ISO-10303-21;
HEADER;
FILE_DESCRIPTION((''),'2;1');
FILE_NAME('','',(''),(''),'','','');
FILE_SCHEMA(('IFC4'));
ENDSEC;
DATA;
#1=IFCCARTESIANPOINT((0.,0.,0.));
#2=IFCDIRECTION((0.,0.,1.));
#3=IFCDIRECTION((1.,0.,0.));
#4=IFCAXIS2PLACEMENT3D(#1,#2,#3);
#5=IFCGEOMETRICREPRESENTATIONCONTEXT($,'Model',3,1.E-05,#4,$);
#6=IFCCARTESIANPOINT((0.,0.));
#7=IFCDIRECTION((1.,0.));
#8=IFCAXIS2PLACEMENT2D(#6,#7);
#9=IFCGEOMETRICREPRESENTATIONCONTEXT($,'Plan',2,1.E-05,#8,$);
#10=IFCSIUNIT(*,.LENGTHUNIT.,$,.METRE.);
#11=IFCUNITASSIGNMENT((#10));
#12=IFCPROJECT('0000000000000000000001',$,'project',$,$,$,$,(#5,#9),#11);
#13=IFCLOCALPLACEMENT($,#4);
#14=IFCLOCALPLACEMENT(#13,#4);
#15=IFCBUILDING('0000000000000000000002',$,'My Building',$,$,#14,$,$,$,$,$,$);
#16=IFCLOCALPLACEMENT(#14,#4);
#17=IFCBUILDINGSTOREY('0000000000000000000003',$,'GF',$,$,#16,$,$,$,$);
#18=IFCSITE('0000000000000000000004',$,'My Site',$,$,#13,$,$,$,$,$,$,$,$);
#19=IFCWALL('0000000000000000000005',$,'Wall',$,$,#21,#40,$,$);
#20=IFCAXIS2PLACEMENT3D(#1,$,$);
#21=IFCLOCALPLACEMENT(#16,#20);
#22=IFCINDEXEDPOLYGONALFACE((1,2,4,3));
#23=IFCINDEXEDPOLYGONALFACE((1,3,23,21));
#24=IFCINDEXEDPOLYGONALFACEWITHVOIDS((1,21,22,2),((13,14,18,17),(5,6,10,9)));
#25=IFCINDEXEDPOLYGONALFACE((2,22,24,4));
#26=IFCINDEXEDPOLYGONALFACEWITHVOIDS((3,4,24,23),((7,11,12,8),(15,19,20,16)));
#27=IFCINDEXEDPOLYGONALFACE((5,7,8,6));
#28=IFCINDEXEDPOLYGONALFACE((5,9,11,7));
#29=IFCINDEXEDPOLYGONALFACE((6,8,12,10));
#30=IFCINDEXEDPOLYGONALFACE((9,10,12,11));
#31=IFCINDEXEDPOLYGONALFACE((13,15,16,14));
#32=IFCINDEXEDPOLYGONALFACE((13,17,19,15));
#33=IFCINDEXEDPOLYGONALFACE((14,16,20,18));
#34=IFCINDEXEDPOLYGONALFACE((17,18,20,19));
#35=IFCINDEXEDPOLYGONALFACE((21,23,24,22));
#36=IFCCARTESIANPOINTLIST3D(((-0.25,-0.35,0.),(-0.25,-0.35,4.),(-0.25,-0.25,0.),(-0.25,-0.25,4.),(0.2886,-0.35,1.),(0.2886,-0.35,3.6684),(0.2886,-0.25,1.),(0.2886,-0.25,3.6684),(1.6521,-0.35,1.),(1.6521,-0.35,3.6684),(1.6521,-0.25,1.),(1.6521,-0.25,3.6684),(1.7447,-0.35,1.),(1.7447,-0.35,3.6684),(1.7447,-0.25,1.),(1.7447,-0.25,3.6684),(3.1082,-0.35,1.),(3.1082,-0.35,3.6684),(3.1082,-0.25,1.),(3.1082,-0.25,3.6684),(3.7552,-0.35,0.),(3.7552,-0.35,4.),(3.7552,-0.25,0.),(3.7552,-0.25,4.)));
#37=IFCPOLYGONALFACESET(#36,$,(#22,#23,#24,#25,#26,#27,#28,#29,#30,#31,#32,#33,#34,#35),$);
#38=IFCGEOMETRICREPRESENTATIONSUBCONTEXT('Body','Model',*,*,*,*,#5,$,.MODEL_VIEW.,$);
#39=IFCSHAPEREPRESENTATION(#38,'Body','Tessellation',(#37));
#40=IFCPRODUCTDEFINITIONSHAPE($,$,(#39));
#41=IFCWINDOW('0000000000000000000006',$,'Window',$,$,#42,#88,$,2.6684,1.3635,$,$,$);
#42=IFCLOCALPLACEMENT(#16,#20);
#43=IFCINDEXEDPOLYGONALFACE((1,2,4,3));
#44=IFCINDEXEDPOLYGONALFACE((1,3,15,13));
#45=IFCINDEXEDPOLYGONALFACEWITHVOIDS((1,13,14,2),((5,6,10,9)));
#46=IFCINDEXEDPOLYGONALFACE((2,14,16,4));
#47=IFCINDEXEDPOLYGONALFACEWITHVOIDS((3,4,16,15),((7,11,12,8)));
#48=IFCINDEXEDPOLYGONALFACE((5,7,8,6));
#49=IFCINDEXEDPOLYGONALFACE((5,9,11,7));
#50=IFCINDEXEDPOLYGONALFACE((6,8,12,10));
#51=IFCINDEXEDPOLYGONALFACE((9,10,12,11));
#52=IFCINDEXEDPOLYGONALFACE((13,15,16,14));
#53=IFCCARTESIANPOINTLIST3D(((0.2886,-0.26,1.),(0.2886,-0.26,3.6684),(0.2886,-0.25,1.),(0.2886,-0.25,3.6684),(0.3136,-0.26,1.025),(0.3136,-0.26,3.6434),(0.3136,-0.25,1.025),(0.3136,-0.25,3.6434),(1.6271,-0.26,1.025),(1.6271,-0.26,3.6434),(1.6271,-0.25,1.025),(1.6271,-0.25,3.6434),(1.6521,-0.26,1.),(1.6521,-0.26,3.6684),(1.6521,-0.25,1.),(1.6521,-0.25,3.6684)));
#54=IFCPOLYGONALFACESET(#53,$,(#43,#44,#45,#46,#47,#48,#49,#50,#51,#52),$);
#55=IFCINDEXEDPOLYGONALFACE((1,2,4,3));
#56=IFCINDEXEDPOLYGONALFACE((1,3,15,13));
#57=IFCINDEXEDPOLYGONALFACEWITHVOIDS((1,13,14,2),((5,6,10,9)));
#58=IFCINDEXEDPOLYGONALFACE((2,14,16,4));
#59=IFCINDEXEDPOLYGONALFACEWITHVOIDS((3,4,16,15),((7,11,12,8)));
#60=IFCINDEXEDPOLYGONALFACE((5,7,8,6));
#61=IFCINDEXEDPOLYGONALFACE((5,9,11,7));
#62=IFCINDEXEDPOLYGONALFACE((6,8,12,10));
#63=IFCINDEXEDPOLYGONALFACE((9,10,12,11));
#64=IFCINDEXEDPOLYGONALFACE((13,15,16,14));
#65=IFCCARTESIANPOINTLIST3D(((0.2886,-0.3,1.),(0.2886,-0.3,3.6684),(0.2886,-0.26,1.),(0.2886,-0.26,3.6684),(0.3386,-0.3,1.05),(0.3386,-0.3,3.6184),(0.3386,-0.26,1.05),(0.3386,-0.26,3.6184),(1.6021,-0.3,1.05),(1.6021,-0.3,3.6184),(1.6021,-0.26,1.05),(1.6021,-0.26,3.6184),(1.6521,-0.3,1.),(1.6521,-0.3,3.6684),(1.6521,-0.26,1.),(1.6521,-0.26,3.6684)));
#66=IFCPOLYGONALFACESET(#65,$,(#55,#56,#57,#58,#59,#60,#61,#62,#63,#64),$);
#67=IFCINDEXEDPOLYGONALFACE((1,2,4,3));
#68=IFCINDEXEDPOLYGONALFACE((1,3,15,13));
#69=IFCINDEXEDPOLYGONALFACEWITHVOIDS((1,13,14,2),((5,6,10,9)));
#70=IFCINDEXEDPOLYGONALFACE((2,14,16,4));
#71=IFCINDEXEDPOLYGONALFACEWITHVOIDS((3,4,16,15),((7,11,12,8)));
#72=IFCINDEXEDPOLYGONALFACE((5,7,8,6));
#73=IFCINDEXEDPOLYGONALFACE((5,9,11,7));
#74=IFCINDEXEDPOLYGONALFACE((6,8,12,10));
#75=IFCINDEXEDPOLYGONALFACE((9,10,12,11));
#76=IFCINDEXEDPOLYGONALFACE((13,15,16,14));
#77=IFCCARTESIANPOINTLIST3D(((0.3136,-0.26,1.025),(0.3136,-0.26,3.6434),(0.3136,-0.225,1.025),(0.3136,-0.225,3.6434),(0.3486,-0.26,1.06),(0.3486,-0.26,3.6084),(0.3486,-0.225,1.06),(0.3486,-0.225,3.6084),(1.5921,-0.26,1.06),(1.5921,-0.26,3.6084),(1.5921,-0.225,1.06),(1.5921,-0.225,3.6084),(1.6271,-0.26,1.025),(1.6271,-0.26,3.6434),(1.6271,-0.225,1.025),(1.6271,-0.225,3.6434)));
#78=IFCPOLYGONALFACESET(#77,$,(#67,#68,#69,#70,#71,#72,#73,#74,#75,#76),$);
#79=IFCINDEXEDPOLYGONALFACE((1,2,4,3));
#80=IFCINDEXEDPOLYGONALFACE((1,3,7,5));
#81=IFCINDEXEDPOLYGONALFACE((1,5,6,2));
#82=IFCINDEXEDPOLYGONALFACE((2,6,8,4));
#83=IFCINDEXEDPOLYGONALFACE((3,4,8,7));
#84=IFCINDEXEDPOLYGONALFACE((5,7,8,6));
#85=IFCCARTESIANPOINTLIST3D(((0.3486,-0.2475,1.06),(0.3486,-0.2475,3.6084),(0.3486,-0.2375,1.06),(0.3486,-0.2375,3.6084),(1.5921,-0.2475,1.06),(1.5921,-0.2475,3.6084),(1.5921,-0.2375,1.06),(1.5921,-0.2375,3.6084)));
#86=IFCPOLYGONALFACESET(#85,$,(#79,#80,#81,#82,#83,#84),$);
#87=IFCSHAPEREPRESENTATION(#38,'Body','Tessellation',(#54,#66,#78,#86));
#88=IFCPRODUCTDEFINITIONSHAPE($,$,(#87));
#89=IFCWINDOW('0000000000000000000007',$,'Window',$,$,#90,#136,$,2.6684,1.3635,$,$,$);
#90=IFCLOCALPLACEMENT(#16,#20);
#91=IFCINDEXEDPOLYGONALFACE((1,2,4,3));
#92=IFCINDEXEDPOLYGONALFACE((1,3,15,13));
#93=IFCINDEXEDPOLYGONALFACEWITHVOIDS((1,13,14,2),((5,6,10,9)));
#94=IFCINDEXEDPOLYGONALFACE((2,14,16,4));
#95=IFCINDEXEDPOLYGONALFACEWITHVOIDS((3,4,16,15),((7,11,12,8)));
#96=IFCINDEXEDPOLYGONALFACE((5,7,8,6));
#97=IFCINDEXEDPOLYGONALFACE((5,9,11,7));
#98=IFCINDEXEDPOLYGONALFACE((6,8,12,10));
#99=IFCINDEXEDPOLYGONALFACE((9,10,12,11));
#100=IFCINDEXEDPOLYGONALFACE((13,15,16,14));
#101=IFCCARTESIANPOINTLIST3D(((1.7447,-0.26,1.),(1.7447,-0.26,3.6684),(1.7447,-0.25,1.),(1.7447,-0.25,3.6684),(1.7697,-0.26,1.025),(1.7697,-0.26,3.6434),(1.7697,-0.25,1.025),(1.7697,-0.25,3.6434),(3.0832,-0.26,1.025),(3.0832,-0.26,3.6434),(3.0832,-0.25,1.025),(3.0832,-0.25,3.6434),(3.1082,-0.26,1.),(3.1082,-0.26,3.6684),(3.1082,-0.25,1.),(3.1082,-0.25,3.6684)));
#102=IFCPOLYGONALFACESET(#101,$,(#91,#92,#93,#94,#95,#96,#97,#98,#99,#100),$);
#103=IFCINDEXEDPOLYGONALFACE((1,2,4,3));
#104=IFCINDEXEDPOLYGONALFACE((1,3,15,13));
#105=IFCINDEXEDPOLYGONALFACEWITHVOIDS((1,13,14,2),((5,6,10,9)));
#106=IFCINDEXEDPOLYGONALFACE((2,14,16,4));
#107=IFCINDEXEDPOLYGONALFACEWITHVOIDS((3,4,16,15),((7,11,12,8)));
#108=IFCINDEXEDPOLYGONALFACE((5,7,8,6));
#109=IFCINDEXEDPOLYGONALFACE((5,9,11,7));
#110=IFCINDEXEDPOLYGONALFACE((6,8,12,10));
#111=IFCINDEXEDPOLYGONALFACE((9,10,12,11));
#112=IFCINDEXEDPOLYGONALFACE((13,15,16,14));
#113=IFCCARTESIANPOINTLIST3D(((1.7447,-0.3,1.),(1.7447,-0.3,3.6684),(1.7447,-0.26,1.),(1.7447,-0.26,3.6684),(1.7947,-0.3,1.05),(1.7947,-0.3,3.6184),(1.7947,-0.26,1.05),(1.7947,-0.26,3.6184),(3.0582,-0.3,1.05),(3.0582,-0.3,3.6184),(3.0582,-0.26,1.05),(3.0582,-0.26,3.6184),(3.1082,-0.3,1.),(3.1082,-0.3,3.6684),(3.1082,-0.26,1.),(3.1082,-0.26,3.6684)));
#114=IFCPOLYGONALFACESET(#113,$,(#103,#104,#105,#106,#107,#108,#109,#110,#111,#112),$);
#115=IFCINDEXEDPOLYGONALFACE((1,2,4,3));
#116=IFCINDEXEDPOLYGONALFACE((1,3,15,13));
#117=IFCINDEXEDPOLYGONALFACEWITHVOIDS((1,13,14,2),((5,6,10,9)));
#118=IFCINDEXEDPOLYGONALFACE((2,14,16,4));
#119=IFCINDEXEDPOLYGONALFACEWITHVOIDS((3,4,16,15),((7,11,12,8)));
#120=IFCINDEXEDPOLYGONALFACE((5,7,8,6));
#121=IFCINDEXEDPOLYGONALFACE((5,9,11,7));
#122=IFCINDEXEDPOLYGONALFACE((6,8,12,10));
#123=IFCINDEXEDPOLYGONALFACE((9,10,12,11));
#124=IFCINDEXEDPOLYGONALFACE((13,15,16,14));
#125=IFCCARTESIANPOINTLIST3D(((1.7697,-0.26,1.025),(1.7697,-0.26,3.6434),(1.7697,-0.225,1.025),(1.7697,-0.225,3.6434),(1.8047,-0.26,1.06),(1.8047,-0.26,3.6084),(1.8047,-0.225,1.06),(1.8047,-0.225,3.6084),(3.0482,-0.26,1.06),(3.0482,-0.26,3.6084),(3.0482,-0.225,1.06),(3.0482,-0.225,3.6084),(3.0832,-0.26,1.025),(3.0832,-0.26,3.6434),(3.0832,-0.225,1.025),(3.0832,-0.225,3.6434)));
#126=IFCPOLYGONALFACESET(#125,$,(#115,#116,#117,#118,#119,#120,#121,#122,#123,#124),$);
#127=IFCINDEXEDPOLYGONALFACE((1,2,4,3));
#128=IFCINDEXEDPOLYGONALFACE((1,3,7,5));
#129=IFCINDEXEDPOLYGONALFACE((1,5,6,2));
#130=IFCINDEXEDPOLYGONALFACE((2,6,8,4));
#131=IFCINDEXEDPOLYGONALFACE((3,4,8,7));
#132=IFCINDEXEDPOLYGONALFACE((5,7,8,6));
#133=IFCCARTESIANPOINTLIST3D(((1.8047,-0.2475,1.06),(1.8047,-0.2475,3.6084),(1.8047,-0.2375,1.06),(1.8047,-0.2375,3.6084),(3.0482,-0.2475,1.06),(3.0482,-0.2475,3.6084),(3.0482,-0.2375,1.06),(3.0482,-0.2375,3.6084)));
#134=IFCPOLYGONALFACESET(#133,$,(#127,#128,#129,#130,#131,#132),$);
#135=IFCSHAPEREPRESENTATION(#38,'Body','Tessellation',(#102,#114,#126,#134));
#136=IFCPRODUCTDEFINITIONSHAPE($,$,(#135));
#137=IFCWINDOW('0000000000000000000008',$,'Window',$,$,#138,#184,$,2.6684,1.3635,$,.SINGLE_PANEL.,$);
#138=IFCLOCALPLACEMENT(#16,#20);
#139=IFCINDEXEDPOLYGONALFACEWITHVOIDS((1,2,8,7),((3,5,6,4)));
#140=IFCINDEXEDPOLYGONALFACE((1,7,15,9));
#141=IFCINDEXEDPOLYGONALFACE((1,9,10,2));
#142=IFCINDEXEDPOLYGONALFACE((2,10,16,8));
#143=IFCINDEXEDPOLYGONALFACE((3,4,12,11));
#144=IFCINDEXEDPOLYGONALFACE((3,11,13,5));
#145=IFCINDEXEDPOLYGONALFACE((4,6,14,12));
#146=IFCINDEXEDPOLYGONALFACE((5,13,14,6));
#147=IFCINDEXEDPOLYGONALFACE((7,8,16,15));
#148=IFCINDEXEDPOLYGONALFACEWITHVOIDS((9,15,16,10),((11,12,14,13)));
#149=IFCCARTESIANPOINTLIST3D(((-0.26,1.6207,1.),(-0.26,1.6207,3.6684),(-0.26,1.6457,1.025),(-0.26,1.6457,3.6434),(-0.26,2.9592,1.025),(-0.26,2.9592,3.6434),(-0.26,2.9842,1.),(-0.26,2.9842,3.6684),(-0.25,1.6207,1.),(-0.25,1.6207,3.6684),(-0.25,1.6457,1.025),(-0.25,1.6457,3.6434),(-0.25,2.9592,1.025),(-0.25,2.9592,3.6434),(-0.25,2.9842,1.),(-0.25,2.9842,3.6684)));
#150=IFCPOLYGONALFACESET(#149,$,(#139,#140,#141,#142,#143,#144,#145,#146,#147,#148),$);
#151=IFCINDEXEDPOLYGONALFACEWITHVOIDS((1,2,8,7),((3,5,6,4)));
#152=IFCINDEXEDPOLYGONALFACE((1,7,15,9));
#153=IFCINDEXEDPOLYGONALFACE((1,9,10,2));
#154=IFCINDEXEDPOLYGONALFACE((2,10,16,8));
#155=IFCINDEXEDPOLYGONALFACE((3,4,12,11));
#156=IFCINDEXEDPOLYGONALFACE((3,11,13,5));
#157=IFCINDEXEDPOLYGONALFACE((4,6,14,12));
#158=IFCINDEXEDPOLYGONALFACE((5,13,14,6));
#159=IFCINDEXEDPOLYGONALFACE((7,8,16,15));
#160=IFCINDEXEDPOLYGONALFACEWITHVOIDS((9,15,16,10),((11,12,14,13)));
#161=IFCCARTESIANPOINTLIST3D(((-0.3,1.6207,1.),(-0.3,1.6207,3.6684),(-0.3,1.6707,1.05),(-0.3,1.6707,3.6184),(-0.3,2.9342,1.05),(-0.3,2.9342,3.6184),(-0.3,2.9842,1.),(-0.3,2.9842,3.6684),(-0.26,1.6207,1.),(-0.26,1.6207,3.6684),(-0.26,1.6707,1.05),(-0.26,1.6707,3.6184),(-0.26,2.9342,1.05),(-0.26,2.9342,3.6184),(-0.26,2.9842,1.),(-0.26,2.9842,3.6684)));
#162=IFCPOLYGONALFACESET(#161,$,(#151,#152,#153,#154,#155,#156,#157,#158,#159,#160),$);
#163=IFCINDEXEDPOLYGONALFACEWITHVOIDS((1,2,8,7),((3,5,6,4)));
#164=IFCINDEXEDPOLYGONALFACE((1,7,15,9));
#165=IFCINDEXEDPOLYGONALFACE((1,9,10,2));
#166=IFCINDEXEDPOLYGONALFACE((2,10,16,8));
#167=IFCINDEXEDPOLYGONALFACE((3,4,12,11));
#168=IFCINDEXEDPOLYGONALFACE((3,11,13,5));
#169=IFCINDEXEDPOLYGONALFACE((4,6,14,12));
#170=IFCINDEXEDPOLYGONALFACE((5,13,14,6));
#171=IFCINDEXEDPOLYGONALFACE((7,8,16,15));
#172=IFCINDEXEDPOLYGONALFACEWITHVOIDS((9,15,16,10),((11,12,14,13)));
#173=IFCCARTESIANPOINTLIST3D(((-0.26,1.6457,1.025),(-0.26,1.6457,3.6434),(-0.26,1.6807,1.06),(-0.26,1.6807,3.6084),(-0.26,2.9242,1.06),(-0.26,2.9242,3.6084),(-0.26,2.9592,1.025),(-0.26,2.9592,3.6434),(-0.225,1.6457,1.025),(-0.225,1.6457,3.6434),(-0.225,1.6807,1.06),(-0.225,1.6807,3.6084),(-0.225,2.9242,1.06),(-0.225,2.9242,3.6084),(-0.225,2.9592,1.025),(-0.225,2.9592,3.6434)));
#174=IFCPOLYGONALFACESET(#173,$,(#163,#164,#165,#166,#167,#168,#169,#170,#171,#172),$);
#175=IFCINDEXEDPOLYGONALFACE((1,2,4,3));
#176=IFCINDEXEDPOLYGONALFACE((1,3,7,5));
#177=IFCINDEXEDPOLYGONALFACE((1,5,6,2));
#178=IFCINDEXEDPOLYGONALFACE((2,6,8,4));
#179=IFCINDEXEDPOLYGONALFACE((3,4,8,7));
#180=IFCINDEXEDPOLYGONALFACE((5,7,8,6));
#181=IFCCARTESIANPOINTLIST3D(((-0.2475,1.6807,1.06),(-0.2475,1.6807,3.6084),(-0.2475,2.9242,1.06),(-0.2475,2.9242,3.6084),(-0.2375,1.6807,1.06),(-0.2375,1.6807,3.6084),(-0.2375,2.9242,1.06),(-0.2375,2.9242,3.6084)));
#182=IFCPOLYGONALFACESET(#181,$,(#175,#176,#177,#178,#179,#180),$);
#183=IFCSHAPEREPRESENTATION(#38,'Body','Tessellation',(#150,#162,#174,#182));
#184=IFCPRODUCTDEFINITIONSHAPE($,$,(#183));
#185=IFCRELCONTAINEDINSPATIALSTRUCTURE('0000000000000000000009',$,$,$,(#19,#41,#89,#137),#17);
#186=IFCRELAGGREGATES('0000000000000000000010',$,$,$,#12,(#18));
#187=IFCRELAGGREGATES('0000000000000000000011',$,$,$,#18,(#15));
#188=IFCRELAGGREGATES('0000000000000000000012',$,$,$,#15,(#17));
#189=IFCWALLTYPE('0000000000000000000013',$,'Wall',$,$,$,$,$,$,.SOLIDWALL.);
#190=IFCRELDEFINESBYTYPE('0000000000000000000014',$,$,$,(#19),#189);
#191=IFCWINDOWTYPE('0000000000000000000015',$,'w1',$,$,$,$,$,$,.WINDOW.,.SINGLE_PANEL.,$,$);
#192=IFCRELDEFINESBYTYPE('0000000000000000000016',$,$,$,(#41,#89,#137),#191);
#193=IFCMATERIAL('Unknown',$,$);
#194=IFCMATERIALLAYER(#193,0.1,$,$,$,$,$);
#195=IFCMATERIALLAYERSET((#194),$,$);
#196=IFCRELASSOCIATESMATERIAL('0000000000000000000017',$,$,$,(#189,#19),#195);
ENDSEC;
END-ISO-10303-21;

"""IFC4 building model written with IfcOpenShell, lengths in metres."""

from ifc_helpers import new_model, entity, si_unit, frame, origin_with_axes, origin_2d_with_axis, place, context, subcontext, project, spatial, line, indexed_curve, outline, extrude, shape, source, transform, mapped, material, layer, layer_set, layer_usage, type_object, type_shapes, element, fill, save


model = new_model("IFC4")

# Units and contexts
model_context = context("Model", 3, precision=1e-05, world=origin_with_axes())
plan_context = context("Plan", 2, precision=1e-05, world=origin_2d_with_axis())
body_context_1 = subcontext(model_context, "Body", "Model", "MODEL_VIEW")
body_context_2 = subcontext(plan_context, "Body", "Plan", "PLAN_VIEW")
ifc_project = project(units=[si_unit("LENGTHUNIT", "METRE")], contexts=[model_context, plan_context])

# Site, building, storey
site_placement = place(None, origin_with_axes())
site = spatial("IfcSite", under=ifc_project, at=site_placement, Name="My Site")
building_placement = place(site_placement, origin_with_axes())
building = spatial("IfcBuilding", under=site, at=building_placement, Name="My Building")
storey_placement = place(building_placement, origin_with_axes())
storey = spatial("IfcBuildingStorey", under=building, at=storey_placement, Name="GF")

# Shared definitions
ifc_material = material(Name="Unknown")

# Wall, openings, windows
ifc_layer_1 = layer(ifc_material, 0.1)
ifc_layer_set_1 = layer_set([ifc_layer_1])
wall_type = type_object("IfcWallType", Name="Wall", PredefinedType="SOLIDWALL", material=ifc_layer_set_1)
shared_shape_1 = source(origin_with_axes(), body_context_1, "Body", "SweptSolid", [
    extrude(outline(indexed_curve([(0.0, 0.0), (1.3635, 0.0), (1.3635, 2.6684), (0.0, 2.6684)], segments=[line(1, 2, 3, 4, 1)])), frame((0.0, -0.6, 0.0), z_axis=(0.0, -1.0, 0.0), x_axis=(1.0, 0.0, 0.0)), (0.0, 0.0, -1.0), 1.2),
])
window_type_1 = type_object("IfcWindowType", Name="w1", PartitioningType="SINGLE_PANEL", PredefinedType="WINDOW")
shared_shape_2 = source(origin_with_axes(), body_context_1, "Body", "SweptSolid", [
    extrude(outline(indexed_curve([(0.0, 0.0), (1.3635, 0.0), (1.3635, 2.6684), (0.0, 2.6684)], segments=[line(1, 2, 3, 4, 1)]), holes=[indexed_curve([(0.025, 0.025), (1.3385, 0.025), (1.3385, 2.6434), (0.025, 2.6434)], segments=[line(1, 2, 3, 4, 1)])]), frame((0.0, 0.09, 0.0), z_axis=(0.0, -1.0, 0.0), x_axis=(1.0, 0.0, 0.0)), (0.0, 0.0, -1.0), 0.01),
    extrude(outline(indexed_curve([(0.0, 0.0), (1.3635, 0.0), (1.3635, 2.6684), (0.0, 2.6684)], segments=[line(1, 2, 3, 4, 1)]), holes=[indexed_curve([(0.05, 0.05), (1.3135, 0.05), (1.3135, 2.6184), (0.05, 2.6184)], segments=[line(1, 2, 3, 4, 1)])]), frame((0.0, 0.05, 0.0), z_axis=(0.0, -1.0, 0.0), x_axis=(1.0, 0.0, 0.0)), (0.0, 0.0, -1.0), 0.04),
    extrude(outline(indexed_curve([(0.0, 0.0), (1.3135, 0.0), (1.3135, 2.6184), (0.0, 2.6184)], segments=[line(1, 2, 3, 4, 1)]), holes=[indexed_curve([(0.035, 0.035), (1.2785, 0.035), (1.2785, 2.5834), (0.035, 2.5834)], segments=[line(1, 2, 3, 4, 1)])]), frame((0.025, 0.09, 0.025), z_axis=(0.0, -1.0, 0.0), x_axis=(1.0, 0.0, 0.0)), (0.0, 0.0, -1.0), 0.035),
    extrude(outline(indexed_curve([(0.035, 0.035), (1.2785, 0.035), (1.2785, 2.5834), (0.035, 2.5834)], segments=[line(1, 2, 3, 4, 1)])), frame((0.025, 0.1025, 0.025), z_axis=(0.0, -1.0, 0.0), x_axis=(1.0, 0.0, 0.0)), (0.0, 0.0, -1.0), 0.01),
])
shared_shape_3 = source(origin_with_axes(), body_context_2, "Body", "Curve2D", [
    entity("IfcIndexedPolyCurve", entity("IfcCartesianPointList2D", [[0.05, 0.05], [1.3135, 0.05]])),
    entity("IfcIndexedPolyCurve", entity("IfcCartesianPointList2D", [[0.0, 0.1], [0.025, 0.1], [0.025, 0.09], [0.05, 0.09], [0.05, 0.05], [0.0, 0.05]]), [entity("IfcLineIndex", [1, 2, 3, 4, 5, 6, 1])]),
    entity("IfcIndexedPolyCurve", entity("IfcCartesianPointList2D", [[1.3635, 0.1], [1.3385, 0.1], [1.3385, 0.09], [1.3135, 0.09], [1.3135, 0.05], [1.3635, 0.05]]), [entity("IfcLineIndex", [1, 2, 3, 4, 5, 6, 1])]),
    entity("IfcIndexedPolyCurve", entity("IfcCartesianPointList2D", [[0.025, 0.09], [0.06, 0.09], [0.06, 0.125], [0.025, 0.125]]), [entity("IfcLineIndex", [1, 2, 3, 4, 1])]),
    entity("IfcIndexedPolyCurve", entity("IfcCartesianPointList2D", [[1.3385, 0.09], [1.3035, 0.09], [1.3035, 0.125], [1.3385, 0.125]]), [entity("IfcLineIndex", [1, 2, 3, 4, 1])]),
    entity("IfcIndexedPolyCurve", entity("IfcCartesianPointList2D", [[0.06, 0.09], [1.3035, 0.09]])),
    entity("IfcIndexedPolyCurve", entity("IfcCartesianPointList2D", [[0.06, 0.125], [1.3035, 0.125]])),
    entity("IfcIndexedPolyCurve", entity("IfcCartesianPointList2D", [[0.06, 0.1075], [1.3035, 0.1075]])),
])
type_shapes(window_type_1, [shared_shape_2, shared_shape_3])
ifc_layer_usage_1 = layer_usage(ifc_layer_set_1, "AXIS2", "POSITIVE", 0.0)
wall_1_placement = place(storey_placement, frame((3.7552, -0.25, 0.0), z_axis=(0.0, 0.0, 1.0), x_axis=(-1.0, 0.0, 0.0)))
wall_1 = element("IfcWall", 1, at=wall_1_placement, inside=storey, type_object=wall_type, material=ifc_layer_usage_1, Name="Wall", context=body_context_1, shape_type="SweptSolid", body=[
    extrude(outline(indexed_curve([(0.0, 0.0), (0.0, 0.1), (4.0052, 0.1), (4.0052, 0.0)], segments=[line(1, 2, 3, 4, 1)])), origin_with_axes(), (0.0, 0.0, 1.0), 4.0),
])
opening_1_placement = place(wall_1_placement, frame((3.4667, 0.1, 1.0), z_axis=(0.0, 0.0, 1.0), x_axis=(-1.0, 0.0, 0.0)))
opening_1 = element("IfcOpeningElement", 2, at=opening_1_placement, cuts=wall_1, PredefinedType="OPENING", context=body_context_1, shape_type="MappedRepresentation", body=[
    mapped(shared_shape_1, transform((0.0, 0.0, 0.0), x_axis=(1.0, 0.0, 0.0), y_axis=(0.0, 1.0, 0.0), z_axis=(0.0, 0.0, 1.0), scale=1.0)),
])
opening_2_placement = place(wall_1_placement, frame((2.0106, 0.1, 1.0), z_axis=(0.0, 0.0, 1.0), x_axis=(-1.0, 0.0, 0.0)))
opening_2 = element("IfcOpeningElement", 3, at=opening_2_placement, cuts=wall_1, PredefinedType="OPENING", context=body_context_1, shape_type="MappedRepresentation", body=[
    mapped(shared_shape_1, transform((0.0, 0.0, 0.0), x_axis=(1.0, 0.0, 0.0), y_axis=(0.0, 1.0, 0.0), z_axis=(0.0, 0.0, 1.0), scale=1.0)),
])
window_1_placement = place(opening_1_placement, frame((0.0, 0.0, 0.0), z_axis=(0.0, 0.0, 1.0), x_axis=(1.0, 0.0, 0.0)))
window_1 = element("IfcWindow", 4, at=window_1_placement, inside=storey, type_object=window_type_1, Name="Window", OverallHeight=2.6684, OverallWidth=1.3635, shapes=[
    shape(body_context_1, "Body", "MappedRepresentation", [mapped(shared_shape_2, transform((0.0, 0.0, 0.0), x_axis=(1.0, 0.0, 0.0), y_axis=(0.0, 1.0, 0.0), z_axis=(0.0, 0.0, 1.0), scale=1.0))]),
    shape(body_context_2, "Body", "MappedRepresentation", [mapped(shared_shape_3, transform((0.0, 0.0, 0.0), x_axis=(1.0, 0.0, 0.0), y_axis=(0.0, 1.0, 0.0), z_axis=(0.0, 0.0, 1.0), scale=1.0))]),
])
fill(opening_1, window_1)
window_2_placement = place(opening_2_placement, frame((0.0, 0.0, 0.0), z_axis=(0.0, 0.0, 1.0), x_axis=(1.0, 0.0, 0.0)))
window_2 = element("IfcWindow", 5, at=window_2_placement, inside=storey, type_object=window_type_1, Name="Window", OverallHeight=2.6684, OverallWidth=1.3635, shapes=[
    shape(body_context_1, "Body", "MappedRepresentation", [mapped(shared_shape_2, transform((0.0, 0.0, 0.0), x_axis=(1.0, 0.0, 0.0), y_axis=(0.0, 1.0, 0.0), z_axis=(0.0, 0.0, 1.0), scale=1.0))]),
    shape(body_context_2, "Body", "MappedRepresentation", [mapped(shared_shape_3, transform((0.0, 0.0, 0.0), x_axis=(1.0, 0.0, 0.0), y_axis=(0.0, 1.0, 0.0), z_axis=(0.0, 0.0, 1.0), scale=1.0))]),
])
fill(opening_2, window_2)

# Window
window_3_placement = place(storey_placement, frame((-0.35, 2.9842, 1.0), z_axis=(0.0, 0.0, 1.0), x_axis=(0.0, -1.0, 0.0)))
element("IfcWindow", 6, at=window_3_placement, inside=storey, type_object=window_type_1, Name="Window", OverallHeight=2.6684, OverallWidth=1.3635, PartitioningType="SINGLE_PANEL", shapes=[
    shape(body_context_1, "Body", "MappedRepresentation", [mapped(shared_shape_2, transform((0.0, 0.0, 0.0), x_axis=(1.0, 0.0, 0.0), y_axis=(0.0, 1.0, 0.0), z_axis=(0.0, 0.0, 1.0), scale=1.0))]),
    shape(body_context_2, "Body", "MappedRepresentation", [mapped(shared_shape_3, transform((0.0, 0.0, 0.0), x_axis=(1.0, 0.0, 0.0), y_axis=(0.0, 1.0, 0.0), z_axis=(0.0, 0.0, 1.0), scale=1.0))]),
])

save(model, "model.ifc")
